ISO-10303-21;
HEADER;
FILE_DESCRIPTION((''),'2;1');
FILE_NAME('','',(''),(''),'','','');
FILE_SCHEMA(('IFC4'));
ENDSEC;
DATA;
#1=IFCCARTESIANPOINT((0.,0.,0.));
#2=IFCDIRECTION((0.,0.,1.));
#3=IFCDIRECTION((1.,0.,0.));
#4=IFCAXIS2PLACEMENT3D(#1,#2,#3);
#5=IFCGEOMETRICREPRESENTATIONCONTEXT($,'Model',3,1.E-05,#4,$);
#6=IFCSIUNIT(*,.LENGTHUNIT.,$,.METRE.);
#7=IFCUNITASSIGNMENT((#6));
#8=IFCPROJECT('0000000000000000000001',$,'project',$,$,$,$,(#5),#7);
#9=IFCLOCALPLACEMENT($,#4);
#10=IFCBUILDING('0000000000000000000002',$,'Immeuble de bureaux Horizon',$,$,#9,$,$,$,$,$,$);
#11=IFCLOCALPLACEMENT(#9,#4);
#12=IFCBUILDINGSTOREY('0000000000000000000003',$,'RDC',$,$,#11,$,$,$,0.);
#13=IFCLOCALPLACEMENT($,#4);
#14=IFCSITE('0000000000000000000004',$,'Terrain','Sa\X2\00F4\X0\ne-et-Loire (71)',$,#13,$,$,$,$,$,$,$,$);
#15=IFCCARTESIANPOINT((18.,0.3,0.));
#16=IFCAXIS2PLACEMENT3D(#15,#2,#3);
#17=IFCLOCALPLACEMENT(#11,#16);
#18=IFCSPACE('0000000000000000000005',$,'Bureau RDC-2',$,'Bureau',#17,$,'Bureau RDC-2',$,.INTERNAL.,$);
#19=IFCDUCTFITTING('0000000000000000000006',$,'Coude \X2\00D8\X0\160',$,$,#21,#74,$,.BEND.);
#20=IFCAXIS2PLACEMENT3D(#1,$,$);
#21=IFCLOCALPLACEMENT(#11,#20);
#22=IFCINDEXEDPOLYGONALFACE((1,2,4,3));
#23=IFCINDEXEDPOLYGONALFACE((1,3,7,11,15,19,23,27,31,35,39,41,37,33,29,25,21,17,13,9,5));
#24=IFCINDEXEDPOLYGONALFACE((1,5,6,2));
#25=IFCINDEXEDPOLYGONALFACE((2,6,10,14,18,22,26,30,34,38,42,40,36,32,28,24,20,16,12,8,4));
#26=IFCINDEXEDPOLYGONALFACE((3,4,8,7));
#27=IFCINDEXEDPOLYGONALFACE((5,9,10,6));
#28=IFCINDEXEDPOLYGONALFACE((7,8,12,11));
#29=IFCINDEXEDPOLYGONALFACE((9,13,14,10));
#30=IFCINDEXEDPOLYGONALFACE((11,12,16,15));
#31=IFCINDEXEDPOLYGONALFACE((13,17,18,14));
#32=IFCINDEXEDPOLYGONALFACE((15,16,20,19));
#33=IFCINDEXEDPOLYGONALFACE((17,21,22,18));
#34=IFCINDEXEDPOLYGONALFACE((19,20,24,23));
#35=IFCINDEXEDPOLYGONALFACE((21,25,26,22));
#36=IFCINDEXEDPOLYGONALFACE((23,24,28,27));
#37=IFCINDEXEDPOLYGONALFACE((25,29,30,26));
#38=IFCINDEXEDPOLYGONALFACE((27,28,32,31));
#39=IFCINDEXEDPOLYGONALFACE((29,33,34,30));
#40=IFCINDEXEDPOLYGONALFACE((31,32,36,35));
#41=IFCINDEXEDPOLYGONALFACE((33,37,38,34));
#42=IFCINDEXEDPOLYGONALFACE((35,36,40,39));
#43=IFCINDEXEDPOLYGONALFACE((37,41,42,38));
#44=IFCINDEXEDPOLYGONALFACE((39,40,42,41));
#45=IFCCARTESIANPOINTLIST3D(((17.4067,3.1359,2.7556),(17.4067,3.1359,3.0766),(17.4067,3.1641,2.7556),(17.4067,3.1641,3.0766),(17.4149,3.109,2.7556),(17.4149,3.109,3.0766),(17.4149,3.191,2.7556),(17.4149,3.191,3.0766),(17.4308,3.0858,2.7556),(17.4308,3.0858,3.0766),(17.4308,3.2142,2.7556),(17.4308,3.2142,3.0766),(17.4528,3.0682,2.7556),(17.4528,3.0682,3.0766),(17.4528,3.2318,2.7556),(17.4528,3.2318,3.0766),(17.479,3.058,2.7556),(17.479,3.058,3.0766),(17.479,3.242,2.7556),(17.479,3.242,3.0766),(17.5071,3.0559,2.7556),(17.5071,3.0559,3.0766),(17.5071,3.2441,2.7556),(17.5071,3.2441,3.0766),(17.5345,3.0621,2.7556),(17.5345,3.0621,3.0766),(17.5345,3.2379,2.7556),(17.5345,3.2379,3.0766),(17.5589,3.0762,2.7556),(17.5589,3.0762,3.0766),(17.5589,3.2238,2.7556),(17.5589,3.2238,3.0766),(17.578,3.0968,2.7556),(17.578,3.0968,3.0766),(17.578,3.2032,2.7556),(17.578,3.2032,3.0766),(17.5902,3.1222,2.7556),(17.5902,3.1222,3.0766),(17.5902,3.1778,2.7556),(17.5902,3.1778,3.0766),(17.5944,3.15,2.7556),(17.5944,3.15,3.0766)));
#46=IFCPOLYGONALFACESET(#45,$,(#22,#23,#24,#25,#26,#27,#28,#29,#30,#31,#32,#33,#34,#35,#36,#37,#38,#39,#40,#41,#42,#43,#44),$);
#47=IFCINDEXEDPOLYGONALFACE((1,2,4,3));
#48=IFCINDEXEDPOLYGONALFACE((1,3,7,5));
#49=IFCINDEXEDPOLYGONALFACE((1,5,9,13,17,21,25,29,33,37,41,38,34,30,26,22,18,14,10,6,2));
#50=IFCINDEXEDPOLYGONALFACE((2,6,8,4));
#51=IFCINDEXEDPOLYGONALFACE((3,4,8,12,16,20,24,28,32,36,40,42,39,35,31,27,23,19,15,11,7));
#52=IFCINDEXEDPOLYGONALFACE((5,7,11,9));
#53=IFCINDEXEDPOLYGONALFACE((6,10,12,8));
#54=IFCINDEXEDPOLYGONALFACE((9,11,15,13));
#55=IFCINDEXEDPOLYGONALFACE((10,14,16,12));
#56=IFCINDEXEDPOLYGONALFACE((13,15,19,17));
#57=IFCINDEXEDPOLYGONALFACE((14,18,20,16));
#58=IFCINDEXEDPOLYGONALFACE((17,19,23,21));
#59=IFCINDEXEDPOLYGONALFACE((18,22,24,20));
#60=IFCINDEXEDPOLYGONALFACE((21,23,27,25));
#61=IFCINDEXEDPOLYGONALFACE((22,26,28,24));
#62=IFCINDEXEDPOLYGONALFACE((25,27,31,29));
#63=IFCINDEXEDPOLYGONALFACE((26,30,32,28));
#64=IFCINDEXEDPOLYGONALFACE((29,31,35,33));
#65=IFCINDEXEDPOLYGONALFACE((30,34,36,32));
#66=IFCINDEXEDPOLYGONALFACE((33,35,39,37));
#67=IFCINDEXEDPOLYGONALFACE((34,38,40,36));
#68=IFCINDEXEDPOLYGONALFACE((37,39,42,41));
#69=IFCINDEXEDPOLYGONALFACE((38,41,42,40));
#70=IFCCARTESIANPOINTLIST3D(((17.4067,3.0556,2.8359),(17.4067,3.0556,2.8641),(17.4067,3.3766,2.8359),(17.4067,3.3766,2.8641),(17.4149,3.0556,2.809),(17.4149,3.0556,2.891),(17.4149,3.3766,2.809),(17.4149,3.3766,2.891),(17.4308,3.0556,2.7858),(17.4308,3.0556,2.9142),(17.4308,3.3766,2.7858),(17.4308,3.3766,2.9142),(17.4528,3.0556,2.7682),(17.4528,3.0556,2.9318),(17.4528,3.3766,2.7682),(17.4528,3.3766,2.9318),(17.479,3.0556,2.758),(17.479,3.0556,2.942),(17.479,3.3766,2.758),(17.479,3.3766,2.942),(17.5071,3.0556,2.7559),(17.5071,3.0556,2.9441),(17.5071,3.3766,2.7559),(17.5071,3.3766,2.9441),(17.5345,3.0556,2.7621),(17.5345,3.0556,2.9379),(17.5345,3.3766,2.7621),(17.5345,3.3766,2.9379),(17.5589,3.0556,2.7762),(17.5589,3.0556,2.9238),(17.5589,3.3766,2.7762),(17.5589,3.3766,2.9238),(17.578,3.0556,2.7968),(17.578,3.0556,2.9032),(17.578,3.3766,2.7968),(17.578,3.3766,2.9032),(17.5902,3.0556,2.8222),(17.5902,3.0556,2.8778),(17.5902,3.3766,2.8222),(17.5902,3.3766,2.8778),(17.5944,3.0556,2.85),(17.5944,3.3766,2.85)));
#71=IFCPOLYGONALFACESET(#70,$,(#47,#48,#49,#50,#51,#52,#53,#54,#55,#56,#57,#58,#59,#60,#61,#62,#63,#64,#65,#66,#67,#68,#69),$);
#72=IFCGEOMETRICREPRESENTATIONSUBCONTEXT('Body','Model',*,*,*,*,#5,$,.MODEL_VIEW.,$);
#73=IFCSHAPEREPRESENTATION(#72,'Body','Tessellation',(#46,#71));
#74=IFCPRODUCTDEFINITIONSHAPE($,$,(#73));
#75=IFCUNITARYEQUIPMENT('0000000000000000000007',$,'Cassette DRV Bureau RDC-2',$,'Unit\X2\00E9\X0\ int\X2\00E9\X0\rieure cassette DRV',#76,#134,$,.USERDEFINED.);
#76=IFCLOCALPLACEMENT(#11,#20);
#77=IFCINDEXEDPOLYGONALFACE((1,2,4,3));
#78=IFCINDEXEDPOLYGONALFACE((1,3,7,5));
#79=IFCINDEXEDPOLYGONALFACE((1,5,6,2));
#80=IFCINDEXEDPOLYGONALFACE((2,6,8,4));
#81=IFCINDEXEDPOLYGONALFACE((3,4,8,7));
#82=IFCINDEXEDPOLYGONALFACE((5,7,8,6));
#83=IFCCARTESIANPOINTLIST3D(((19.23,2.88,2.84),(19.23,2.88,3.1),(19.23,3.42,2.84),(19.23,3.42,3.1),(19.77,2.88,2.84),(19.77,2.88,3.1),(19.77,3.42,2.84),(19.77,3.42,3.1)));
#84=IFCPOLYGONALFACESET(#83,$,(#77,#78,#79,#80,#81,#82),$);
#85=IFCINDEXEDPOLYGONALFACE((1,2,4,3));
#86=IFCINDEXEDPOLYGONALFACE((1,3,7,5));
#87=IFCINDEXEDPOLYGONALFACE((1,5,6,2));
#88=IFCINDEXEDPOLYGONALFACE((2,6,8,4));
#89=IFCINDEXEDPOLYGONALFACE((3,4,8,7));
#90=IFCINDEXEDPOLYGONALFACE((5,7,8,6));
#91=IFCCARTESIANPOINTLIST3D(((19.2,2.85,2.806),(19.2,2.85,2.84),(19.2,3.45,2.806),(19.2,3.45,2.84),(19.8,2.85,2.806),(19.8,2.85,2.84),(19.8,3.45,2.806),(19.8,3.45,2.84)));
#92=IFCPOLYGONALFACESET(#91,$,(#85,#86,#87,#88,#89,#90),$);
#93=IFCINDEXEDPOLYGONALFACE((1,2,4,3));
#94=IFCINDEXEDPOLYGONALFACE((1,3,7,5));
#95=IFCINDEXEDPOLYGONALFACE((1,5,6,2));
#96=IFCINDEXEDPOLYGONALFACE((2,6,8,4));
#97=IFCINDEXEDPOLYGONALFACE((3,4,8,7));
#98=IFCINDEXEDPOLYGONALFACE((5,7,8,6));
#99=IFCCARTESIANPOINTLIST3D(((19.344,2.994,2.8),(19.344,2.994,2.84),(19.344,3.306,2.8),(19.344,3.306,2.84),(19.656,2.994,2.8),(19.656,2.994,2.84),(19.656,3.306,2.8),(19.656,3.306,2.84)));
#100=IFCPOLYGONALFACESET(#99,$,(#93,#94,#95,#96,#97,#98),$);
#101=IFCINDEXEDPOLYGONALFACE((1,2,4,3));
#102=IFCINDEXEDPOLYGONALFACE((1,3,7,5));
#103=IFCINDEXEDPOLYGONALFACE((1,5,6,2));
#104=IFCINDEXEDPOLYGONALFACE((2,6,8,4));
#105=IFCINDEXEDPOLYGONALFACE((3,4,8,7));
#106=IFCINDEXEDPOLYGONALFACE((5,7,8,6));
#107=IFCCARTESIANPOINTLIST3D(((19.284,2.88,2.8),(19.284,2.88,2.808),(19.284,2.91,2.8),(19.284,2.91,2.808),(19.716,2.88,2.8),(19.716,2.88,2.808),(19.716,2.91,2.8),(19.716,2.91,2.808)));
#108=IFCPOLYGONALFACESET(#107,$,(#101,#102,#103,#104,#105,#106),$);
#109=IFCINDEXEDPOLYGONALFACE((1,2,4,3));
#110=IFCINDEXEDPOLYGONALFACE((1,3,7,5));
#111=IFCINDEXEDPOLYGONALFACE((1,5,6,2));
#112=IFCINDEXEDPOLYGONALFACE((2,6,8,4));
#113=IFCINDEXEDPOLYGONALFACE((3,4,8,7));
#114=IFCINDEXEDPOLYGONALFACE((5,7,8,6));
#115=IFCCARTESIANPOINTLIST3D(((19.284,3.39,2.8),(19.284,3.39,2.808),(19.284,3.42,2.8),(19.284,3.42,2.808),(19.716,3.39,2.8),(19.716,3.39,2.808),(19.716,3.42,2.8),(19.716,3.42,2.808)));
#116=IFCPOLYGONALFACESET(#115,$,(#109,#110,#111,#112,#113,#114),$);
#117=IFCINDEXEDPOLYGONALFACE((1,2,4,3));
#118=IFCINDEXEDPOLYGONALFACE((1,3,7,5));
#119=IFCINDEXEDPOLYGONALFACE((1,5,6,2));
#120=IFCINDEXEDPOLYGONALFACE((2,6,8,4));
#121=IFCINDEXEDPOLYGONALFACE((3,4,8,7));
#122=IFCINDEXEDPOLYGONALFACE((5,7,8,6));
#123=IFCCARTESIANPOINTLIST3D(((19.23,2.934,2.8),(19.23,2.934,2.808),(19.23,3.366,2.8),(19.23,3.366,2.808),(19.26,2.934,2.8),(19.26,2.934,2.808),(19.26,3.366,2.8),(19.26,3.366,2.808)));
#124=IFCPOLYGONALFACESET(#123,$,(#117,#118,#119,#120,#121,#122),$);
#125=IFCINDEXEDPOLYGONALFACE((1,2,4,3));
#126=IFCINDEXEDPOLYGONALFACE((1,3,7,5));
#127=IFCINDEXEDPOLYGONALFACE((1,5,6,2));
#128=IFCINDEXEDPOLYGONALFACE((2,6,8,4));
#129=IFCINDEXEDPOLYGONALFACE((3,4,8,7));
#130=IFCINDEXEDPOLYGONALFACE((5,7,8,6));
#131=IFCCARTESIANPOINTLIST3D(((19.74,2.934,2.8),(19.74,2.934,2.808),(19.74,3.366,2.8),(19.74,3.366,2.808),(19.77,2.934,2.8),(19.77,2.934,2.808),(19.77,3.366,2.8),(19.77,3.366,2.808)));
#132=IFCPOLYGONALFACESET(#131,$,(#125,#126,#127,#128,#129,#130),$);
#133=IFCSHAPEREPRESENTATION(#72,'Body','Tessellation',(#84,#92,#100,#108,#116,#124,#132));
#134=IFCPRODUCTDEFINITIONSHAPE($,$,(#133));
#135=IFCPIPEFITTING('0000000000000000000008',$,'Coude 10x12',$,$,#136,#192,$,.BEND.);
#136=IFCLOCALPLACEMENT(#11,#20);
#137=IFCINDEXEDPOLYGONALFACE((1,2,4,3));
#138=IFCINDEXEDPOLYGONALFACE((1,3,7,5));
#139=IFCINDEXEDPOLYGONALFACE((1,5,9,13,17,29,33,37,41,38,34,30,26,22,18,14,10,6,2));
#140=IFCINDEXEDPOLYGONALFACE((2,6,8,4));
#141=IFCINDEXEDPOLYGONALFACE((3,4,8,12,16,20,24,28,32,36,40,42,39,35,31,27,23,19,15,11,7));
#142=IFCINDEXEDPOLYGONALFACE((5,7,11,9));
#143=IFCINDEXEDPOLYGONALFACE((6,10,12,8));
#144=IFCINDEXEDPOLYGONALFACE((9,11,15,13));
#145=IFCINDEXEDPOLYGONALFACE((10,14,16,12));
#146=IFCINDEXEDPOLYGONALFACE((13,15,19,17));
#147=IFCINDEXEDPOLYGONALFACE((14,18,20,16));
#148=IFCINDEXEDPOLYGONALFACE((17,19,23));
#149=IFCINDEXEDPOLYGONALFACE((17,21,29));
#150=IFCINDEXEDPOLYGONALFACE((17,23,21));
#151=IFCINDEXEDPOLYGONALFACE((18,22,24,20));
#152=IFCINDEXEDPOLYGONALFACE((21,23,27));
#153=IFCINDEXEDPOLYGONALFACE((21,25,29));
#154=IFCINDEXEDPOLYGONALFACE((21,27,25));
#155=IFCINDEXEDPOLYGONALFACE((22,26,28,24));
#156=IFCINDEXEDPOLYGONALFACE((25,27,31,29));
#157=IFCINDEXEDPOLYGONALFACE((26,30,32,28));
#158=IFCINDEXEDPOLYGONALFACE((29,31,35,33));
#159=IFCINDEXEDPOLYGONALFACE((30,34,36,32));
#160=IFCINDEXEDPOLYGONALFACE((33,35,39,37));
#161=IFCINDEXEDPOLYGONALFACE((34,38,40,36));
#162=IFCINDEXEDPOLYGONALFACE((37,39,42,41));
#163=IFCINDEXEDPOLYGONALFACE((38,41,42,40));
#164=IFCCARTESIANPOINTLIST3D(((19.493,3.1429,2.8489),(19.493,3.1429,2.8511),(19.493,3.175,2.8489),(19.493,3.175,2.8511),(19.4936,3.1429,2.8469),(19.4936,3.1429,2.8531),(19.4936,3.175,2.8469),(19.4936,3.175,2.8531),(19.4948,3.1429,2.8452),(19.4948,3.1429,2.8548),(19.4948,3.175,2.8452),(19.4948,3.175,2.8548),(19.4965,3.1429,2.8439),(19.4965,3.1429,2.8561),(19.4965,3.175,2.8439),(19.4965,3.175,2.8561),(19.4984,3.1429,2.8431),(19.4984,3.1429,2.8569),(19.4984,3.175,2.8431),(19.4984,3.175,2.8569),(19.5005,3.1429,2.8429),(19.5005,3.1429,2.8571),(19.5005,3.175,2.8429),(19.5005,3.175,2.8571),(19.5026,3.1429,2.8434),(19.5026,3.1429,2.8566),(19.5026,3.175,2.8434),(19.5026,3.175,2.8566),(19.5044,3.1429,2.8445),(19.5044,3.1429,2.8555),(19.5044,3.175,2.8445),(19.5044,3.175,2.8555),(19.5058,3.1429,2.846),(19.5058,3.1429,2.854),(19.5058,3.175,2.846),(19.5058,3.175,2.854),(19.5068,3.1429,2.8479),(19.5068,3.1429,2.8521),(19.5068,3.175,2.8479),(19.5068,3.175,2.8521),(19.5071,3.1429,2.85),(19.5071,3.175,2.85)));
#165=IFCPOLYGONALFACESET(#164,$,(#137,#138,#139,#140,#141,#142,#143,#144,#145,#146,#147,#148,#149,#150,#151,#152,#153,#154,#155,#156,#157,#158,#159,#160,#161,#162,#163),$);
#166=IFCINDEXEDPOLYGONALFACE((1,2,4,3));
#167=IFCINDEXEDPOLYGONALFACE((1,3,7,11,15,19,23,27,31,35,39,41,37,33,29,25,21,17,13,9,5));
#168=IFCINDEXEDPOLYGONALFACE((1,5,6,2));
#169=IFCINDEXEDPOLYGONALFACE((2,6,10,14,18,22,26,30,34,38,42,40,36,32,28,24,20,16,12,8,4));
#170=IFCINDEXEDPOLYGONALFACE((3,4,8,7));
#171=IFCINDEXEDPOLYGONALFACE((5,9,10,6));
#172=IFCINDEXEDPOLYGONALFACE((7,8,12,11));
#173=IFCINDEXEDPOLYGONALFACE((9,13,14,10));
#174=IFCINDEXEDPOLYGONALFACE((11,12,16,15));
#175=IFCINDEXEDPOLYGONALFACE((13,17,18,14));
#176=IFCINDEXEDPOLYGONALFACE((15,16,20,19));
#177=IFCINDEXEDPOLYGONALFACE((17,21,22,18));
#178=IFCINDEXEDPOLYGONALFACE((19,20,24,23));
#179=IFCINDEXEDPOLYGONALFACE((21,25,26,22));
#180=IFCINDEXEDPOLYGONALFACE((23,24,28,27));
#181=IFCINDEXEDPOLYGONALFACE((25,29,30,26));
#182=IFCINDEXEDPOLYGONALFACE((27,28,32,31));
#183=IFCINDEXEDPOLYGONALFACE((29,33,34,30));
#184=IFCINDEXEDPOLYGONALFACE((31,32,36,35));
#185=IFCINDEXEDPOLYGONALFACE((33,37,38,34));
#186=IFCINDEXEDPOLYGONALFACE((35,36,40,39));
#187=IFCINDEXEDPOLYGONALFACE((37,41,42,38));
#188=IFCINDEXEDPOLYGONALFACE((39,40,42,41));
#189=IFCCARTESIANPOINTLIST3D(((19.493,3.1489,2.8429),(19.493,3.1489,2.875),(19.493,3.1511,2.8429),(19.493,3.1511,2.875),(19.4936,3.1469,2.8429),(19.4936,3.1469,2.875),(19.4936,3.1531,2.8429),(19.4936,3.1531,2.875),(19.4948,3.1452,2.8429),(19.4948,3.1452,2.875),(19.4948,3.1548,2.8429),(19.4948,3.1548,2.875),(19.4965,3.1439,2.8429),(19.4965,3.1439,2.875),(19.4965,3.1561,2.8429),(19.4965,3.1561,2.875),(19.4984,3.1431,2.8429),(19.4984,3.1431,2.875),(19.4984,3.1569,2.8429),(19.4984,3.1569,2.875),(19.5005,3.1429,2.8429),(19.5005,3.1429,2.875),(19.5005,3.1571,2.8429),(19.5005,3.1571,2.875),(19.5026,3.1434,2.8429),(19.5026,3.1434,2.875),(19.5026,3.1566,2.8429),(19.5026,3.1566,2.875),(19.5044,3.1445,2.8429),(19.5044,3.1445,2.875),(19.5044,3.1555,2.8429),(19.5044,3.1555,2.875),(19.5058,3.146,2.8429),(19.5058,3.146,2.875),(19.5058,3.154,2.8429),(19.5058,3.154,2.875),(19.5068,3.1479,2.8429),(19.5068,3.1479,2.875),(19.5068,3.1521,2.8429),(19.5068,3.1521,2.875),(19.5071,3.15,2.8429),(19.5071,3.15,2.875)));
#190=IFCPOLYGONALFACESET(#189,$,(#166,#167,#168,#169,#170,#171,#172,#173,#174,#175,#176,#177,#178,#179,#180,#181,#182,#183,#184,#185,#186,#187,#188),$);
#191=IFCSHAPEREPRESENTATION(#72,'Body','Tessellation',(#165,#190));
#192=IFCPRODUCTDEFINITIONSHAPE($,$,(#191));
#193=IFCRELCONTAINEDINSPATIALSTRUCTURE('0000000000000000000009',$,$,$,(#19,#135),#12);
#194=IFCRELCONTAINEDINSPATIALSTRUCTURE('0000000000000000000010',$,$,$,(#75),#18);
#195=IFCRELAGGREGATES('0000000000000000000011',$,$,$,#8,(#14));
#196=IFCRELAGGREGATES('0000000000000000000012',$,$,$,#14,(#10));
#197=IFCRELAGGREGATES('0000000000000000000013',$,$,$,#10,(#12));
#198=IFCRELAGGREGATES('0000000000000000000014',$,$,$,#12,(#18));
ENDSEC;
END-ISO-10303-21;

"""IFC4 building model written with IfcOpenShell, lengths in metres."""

from ifc_helpers import new_model, si_unit, frame, frame_2d, origin_with_axes, place, context, subcontext, project, spatial, rectangle, circle, extrude, element, save


model = new_model("IFC4")

# Units and contexts
model_context = context("Model", 3, precision=1e-05, world=origin_with_axes())
body_context = subcontext(model_context, "Body", "Model", "MODEL_VIEW")
ifc_project = project(units=[si_unit("LENGTHUNIT", "METRE")], contexts=[model_context])

# Site, building, storey
site_placement = place(None, origin_with_axes())
site = spatial("IfcSite", under=ifc_project, at=site_placement, Name="Terrain", Description="Saône-et-Loire (71)")
building_placement = place(None, origin_with_axes())
building = spatial("IfcBuilding", under=site, at=building_placement, Name="Immeuble de bureaux Horizon")
storey_placement = place(building_placement, origin_with_axes())
storey = spatial("IfcBuildingStorey", under=building, at=storey_placement, Name="RDC", Elevation=0.0)

# Duct fitting
duct_fitting_1_placement = place(storey_placement, frame((17.5, 3.15, 2.85), z_axis=(0.0, 0.0, 1.0), x_axis=(1.0, 0.0, 0.0)))
element("IfcDuctFitting", 1, at=duct_fitting_1_placement, inside=storey, Name="Coude Ø160", PredefinedType="BEND", context=body_context, shape_type="SweptSolid", body=[
    extrude(circle(Radius=0.0944), frame((0.0, 0.0, -0.0944), z_axis=(0.0, 0.0, 1.0), x_axis=(1.0, 0.0, 0.0)), (0.0, 0.0, 1.0), 0.321),
    extrude(circle(Radius=0.0944), frame((0.0, -0.0944, 0.0), z_axis=(0.0, 1.0, 0.0), x_axis=(1.0, 0.0, 0.0)), (0.0, 0.0, 1.0), 0.321),
])

# Shared definitions
space_1_placement = place(storey_placement, frame((18.0, 0.3, 0.0), z_axis=(0.0, 0.0, 1.0), x_axis=(1.0, 0.0, 0.0)))
space_1 = spatial("IfcSpace", under=storey, at=space_1_placement, Name="Bureau RDC-2", ObjectType="Bureau", LongName="Bureau RDC-2", PredefinedType="INTERNAL")

# Unitary equipment
unitary_equipment_1_placement = place(space_1_placement, frame((1.2, 2.55, 2.8), z_axis=(0.0, 0.0, 1.0), x_axis=(1.0, 0.0, 0.0)))
element("IfcUnitaryEquipment", 2, at=unitary_equipment_1_placement, inside=space_1, Name="Cassette DRV Bureau RDC-2", ObjectType="Unité intérieure cassette DRV", PredefinedType="USERDEFINED", context=body_context, shape_type="SweptSolid", body=[
    extrude(rectangle(XDim=0.54, YDim=0.54, at=frame_2d((0.27, 0.27))), frame((0.03, 0.03, 0.04), z_axis=(0.0, 0.0, 1.0), x_axis=(1.0, 0.0, 0.0)), (0.0, 0.0, 1.0), 0.26),
    extrude(rectangle(XDim=0.6, YDim=0.6, at=frame_2d((0.3, 0.3))), frame((0.0, 0.0, 0.006), z_axis=(0.0, 0.0, 1.0), x_axis=(1.0, 0.0, 0.0)), (0.0, 0.0, 1.0), 0.034),
    extrude(rectangle(XDim=0.312, YDim=0.312, at=frame_2d((0.156, 0.156))), frame((0.144, 0.144, 0.0), z_axis=(0.0, 0.0, 1.0), x_axis=(1.0, 0.0, 0.0)), (0.0, 0.0, 1.0), 0.04),
    extrude(rectangle(XDim=0.432, YDim=0.03, at=frame_2d((0.216, 0.015))), frame((0.084, 0.03, 0.0), z_axis=(0.0, 0.0, 1.0), x_axis=(1.0, 0.0, 0.0)), (0.0, 0.0, 1.0), 0.008),
    extrude(rectangle(XDim=0.432, YDim=0.03, at=frame_2d((0.216, 0.015))), frame((0.084, 0.54, 0.0), z_axis=(0.0, 0.0, 1.0), x_axis=(1.0, 0.0, 0.0)), (0.0, 0.0, 1.0), 0.008),
    extrude(rectangle(XDim=0.03, YDim=0.432, at=frame_2d((0.015, 0.216))), frame((0.03, 0.084, 0.0), z_axis=(0.0, 0.0, 1.0), x_axis=(1.0, 0.0, 0.0)), (0.0, 0.0, 1.0), 0.008),
    extrude(rectangle(XDim=0.03, YDim=0.432, at=frame_2d((0.015, 0.216))), frame((0.54, 0.084, 0.0), z_axis=(0.0, 0.0, 1.0), x_axis=(1.0, 0.0, 0.0)), (0.0, 0.0, 1.0), 0.008),
])

# Pipe fitting
pipe_fitting_1_placement = place(storey_placement, frame((19.5, 3.15, 2.85), z_axis=(0.0, 0.0, 1.0), x_axis=(1.0, 0.0, 0.0)))
element("IfcPipeFitting", 3, at=pipe_fitting_1_placement, inside=storey, Name="Coude 10x12", PredefinedType="BEND", context=body_context, shape_type="SweptSolid", body=[
    extrude(circle(Radius=0.0071), frame((0.0, -0.0071, 0.0), z_axis=(0.0, 1.0, 0.0), x_axis=(1.0, 0.0, 0.0)), (0.0, 0.0, 1.0), 0.0321),
    extrude(circle(Radius=0.0071), frame((0.0, 0.0, -0.0071), z_axis=(0.0, 0.0, 1.0), x_axis=(1.0, 0.0, 0.0)), (0.0, 0.0, 1.0), 0.0321),
])

save(model, "model.ifc")
